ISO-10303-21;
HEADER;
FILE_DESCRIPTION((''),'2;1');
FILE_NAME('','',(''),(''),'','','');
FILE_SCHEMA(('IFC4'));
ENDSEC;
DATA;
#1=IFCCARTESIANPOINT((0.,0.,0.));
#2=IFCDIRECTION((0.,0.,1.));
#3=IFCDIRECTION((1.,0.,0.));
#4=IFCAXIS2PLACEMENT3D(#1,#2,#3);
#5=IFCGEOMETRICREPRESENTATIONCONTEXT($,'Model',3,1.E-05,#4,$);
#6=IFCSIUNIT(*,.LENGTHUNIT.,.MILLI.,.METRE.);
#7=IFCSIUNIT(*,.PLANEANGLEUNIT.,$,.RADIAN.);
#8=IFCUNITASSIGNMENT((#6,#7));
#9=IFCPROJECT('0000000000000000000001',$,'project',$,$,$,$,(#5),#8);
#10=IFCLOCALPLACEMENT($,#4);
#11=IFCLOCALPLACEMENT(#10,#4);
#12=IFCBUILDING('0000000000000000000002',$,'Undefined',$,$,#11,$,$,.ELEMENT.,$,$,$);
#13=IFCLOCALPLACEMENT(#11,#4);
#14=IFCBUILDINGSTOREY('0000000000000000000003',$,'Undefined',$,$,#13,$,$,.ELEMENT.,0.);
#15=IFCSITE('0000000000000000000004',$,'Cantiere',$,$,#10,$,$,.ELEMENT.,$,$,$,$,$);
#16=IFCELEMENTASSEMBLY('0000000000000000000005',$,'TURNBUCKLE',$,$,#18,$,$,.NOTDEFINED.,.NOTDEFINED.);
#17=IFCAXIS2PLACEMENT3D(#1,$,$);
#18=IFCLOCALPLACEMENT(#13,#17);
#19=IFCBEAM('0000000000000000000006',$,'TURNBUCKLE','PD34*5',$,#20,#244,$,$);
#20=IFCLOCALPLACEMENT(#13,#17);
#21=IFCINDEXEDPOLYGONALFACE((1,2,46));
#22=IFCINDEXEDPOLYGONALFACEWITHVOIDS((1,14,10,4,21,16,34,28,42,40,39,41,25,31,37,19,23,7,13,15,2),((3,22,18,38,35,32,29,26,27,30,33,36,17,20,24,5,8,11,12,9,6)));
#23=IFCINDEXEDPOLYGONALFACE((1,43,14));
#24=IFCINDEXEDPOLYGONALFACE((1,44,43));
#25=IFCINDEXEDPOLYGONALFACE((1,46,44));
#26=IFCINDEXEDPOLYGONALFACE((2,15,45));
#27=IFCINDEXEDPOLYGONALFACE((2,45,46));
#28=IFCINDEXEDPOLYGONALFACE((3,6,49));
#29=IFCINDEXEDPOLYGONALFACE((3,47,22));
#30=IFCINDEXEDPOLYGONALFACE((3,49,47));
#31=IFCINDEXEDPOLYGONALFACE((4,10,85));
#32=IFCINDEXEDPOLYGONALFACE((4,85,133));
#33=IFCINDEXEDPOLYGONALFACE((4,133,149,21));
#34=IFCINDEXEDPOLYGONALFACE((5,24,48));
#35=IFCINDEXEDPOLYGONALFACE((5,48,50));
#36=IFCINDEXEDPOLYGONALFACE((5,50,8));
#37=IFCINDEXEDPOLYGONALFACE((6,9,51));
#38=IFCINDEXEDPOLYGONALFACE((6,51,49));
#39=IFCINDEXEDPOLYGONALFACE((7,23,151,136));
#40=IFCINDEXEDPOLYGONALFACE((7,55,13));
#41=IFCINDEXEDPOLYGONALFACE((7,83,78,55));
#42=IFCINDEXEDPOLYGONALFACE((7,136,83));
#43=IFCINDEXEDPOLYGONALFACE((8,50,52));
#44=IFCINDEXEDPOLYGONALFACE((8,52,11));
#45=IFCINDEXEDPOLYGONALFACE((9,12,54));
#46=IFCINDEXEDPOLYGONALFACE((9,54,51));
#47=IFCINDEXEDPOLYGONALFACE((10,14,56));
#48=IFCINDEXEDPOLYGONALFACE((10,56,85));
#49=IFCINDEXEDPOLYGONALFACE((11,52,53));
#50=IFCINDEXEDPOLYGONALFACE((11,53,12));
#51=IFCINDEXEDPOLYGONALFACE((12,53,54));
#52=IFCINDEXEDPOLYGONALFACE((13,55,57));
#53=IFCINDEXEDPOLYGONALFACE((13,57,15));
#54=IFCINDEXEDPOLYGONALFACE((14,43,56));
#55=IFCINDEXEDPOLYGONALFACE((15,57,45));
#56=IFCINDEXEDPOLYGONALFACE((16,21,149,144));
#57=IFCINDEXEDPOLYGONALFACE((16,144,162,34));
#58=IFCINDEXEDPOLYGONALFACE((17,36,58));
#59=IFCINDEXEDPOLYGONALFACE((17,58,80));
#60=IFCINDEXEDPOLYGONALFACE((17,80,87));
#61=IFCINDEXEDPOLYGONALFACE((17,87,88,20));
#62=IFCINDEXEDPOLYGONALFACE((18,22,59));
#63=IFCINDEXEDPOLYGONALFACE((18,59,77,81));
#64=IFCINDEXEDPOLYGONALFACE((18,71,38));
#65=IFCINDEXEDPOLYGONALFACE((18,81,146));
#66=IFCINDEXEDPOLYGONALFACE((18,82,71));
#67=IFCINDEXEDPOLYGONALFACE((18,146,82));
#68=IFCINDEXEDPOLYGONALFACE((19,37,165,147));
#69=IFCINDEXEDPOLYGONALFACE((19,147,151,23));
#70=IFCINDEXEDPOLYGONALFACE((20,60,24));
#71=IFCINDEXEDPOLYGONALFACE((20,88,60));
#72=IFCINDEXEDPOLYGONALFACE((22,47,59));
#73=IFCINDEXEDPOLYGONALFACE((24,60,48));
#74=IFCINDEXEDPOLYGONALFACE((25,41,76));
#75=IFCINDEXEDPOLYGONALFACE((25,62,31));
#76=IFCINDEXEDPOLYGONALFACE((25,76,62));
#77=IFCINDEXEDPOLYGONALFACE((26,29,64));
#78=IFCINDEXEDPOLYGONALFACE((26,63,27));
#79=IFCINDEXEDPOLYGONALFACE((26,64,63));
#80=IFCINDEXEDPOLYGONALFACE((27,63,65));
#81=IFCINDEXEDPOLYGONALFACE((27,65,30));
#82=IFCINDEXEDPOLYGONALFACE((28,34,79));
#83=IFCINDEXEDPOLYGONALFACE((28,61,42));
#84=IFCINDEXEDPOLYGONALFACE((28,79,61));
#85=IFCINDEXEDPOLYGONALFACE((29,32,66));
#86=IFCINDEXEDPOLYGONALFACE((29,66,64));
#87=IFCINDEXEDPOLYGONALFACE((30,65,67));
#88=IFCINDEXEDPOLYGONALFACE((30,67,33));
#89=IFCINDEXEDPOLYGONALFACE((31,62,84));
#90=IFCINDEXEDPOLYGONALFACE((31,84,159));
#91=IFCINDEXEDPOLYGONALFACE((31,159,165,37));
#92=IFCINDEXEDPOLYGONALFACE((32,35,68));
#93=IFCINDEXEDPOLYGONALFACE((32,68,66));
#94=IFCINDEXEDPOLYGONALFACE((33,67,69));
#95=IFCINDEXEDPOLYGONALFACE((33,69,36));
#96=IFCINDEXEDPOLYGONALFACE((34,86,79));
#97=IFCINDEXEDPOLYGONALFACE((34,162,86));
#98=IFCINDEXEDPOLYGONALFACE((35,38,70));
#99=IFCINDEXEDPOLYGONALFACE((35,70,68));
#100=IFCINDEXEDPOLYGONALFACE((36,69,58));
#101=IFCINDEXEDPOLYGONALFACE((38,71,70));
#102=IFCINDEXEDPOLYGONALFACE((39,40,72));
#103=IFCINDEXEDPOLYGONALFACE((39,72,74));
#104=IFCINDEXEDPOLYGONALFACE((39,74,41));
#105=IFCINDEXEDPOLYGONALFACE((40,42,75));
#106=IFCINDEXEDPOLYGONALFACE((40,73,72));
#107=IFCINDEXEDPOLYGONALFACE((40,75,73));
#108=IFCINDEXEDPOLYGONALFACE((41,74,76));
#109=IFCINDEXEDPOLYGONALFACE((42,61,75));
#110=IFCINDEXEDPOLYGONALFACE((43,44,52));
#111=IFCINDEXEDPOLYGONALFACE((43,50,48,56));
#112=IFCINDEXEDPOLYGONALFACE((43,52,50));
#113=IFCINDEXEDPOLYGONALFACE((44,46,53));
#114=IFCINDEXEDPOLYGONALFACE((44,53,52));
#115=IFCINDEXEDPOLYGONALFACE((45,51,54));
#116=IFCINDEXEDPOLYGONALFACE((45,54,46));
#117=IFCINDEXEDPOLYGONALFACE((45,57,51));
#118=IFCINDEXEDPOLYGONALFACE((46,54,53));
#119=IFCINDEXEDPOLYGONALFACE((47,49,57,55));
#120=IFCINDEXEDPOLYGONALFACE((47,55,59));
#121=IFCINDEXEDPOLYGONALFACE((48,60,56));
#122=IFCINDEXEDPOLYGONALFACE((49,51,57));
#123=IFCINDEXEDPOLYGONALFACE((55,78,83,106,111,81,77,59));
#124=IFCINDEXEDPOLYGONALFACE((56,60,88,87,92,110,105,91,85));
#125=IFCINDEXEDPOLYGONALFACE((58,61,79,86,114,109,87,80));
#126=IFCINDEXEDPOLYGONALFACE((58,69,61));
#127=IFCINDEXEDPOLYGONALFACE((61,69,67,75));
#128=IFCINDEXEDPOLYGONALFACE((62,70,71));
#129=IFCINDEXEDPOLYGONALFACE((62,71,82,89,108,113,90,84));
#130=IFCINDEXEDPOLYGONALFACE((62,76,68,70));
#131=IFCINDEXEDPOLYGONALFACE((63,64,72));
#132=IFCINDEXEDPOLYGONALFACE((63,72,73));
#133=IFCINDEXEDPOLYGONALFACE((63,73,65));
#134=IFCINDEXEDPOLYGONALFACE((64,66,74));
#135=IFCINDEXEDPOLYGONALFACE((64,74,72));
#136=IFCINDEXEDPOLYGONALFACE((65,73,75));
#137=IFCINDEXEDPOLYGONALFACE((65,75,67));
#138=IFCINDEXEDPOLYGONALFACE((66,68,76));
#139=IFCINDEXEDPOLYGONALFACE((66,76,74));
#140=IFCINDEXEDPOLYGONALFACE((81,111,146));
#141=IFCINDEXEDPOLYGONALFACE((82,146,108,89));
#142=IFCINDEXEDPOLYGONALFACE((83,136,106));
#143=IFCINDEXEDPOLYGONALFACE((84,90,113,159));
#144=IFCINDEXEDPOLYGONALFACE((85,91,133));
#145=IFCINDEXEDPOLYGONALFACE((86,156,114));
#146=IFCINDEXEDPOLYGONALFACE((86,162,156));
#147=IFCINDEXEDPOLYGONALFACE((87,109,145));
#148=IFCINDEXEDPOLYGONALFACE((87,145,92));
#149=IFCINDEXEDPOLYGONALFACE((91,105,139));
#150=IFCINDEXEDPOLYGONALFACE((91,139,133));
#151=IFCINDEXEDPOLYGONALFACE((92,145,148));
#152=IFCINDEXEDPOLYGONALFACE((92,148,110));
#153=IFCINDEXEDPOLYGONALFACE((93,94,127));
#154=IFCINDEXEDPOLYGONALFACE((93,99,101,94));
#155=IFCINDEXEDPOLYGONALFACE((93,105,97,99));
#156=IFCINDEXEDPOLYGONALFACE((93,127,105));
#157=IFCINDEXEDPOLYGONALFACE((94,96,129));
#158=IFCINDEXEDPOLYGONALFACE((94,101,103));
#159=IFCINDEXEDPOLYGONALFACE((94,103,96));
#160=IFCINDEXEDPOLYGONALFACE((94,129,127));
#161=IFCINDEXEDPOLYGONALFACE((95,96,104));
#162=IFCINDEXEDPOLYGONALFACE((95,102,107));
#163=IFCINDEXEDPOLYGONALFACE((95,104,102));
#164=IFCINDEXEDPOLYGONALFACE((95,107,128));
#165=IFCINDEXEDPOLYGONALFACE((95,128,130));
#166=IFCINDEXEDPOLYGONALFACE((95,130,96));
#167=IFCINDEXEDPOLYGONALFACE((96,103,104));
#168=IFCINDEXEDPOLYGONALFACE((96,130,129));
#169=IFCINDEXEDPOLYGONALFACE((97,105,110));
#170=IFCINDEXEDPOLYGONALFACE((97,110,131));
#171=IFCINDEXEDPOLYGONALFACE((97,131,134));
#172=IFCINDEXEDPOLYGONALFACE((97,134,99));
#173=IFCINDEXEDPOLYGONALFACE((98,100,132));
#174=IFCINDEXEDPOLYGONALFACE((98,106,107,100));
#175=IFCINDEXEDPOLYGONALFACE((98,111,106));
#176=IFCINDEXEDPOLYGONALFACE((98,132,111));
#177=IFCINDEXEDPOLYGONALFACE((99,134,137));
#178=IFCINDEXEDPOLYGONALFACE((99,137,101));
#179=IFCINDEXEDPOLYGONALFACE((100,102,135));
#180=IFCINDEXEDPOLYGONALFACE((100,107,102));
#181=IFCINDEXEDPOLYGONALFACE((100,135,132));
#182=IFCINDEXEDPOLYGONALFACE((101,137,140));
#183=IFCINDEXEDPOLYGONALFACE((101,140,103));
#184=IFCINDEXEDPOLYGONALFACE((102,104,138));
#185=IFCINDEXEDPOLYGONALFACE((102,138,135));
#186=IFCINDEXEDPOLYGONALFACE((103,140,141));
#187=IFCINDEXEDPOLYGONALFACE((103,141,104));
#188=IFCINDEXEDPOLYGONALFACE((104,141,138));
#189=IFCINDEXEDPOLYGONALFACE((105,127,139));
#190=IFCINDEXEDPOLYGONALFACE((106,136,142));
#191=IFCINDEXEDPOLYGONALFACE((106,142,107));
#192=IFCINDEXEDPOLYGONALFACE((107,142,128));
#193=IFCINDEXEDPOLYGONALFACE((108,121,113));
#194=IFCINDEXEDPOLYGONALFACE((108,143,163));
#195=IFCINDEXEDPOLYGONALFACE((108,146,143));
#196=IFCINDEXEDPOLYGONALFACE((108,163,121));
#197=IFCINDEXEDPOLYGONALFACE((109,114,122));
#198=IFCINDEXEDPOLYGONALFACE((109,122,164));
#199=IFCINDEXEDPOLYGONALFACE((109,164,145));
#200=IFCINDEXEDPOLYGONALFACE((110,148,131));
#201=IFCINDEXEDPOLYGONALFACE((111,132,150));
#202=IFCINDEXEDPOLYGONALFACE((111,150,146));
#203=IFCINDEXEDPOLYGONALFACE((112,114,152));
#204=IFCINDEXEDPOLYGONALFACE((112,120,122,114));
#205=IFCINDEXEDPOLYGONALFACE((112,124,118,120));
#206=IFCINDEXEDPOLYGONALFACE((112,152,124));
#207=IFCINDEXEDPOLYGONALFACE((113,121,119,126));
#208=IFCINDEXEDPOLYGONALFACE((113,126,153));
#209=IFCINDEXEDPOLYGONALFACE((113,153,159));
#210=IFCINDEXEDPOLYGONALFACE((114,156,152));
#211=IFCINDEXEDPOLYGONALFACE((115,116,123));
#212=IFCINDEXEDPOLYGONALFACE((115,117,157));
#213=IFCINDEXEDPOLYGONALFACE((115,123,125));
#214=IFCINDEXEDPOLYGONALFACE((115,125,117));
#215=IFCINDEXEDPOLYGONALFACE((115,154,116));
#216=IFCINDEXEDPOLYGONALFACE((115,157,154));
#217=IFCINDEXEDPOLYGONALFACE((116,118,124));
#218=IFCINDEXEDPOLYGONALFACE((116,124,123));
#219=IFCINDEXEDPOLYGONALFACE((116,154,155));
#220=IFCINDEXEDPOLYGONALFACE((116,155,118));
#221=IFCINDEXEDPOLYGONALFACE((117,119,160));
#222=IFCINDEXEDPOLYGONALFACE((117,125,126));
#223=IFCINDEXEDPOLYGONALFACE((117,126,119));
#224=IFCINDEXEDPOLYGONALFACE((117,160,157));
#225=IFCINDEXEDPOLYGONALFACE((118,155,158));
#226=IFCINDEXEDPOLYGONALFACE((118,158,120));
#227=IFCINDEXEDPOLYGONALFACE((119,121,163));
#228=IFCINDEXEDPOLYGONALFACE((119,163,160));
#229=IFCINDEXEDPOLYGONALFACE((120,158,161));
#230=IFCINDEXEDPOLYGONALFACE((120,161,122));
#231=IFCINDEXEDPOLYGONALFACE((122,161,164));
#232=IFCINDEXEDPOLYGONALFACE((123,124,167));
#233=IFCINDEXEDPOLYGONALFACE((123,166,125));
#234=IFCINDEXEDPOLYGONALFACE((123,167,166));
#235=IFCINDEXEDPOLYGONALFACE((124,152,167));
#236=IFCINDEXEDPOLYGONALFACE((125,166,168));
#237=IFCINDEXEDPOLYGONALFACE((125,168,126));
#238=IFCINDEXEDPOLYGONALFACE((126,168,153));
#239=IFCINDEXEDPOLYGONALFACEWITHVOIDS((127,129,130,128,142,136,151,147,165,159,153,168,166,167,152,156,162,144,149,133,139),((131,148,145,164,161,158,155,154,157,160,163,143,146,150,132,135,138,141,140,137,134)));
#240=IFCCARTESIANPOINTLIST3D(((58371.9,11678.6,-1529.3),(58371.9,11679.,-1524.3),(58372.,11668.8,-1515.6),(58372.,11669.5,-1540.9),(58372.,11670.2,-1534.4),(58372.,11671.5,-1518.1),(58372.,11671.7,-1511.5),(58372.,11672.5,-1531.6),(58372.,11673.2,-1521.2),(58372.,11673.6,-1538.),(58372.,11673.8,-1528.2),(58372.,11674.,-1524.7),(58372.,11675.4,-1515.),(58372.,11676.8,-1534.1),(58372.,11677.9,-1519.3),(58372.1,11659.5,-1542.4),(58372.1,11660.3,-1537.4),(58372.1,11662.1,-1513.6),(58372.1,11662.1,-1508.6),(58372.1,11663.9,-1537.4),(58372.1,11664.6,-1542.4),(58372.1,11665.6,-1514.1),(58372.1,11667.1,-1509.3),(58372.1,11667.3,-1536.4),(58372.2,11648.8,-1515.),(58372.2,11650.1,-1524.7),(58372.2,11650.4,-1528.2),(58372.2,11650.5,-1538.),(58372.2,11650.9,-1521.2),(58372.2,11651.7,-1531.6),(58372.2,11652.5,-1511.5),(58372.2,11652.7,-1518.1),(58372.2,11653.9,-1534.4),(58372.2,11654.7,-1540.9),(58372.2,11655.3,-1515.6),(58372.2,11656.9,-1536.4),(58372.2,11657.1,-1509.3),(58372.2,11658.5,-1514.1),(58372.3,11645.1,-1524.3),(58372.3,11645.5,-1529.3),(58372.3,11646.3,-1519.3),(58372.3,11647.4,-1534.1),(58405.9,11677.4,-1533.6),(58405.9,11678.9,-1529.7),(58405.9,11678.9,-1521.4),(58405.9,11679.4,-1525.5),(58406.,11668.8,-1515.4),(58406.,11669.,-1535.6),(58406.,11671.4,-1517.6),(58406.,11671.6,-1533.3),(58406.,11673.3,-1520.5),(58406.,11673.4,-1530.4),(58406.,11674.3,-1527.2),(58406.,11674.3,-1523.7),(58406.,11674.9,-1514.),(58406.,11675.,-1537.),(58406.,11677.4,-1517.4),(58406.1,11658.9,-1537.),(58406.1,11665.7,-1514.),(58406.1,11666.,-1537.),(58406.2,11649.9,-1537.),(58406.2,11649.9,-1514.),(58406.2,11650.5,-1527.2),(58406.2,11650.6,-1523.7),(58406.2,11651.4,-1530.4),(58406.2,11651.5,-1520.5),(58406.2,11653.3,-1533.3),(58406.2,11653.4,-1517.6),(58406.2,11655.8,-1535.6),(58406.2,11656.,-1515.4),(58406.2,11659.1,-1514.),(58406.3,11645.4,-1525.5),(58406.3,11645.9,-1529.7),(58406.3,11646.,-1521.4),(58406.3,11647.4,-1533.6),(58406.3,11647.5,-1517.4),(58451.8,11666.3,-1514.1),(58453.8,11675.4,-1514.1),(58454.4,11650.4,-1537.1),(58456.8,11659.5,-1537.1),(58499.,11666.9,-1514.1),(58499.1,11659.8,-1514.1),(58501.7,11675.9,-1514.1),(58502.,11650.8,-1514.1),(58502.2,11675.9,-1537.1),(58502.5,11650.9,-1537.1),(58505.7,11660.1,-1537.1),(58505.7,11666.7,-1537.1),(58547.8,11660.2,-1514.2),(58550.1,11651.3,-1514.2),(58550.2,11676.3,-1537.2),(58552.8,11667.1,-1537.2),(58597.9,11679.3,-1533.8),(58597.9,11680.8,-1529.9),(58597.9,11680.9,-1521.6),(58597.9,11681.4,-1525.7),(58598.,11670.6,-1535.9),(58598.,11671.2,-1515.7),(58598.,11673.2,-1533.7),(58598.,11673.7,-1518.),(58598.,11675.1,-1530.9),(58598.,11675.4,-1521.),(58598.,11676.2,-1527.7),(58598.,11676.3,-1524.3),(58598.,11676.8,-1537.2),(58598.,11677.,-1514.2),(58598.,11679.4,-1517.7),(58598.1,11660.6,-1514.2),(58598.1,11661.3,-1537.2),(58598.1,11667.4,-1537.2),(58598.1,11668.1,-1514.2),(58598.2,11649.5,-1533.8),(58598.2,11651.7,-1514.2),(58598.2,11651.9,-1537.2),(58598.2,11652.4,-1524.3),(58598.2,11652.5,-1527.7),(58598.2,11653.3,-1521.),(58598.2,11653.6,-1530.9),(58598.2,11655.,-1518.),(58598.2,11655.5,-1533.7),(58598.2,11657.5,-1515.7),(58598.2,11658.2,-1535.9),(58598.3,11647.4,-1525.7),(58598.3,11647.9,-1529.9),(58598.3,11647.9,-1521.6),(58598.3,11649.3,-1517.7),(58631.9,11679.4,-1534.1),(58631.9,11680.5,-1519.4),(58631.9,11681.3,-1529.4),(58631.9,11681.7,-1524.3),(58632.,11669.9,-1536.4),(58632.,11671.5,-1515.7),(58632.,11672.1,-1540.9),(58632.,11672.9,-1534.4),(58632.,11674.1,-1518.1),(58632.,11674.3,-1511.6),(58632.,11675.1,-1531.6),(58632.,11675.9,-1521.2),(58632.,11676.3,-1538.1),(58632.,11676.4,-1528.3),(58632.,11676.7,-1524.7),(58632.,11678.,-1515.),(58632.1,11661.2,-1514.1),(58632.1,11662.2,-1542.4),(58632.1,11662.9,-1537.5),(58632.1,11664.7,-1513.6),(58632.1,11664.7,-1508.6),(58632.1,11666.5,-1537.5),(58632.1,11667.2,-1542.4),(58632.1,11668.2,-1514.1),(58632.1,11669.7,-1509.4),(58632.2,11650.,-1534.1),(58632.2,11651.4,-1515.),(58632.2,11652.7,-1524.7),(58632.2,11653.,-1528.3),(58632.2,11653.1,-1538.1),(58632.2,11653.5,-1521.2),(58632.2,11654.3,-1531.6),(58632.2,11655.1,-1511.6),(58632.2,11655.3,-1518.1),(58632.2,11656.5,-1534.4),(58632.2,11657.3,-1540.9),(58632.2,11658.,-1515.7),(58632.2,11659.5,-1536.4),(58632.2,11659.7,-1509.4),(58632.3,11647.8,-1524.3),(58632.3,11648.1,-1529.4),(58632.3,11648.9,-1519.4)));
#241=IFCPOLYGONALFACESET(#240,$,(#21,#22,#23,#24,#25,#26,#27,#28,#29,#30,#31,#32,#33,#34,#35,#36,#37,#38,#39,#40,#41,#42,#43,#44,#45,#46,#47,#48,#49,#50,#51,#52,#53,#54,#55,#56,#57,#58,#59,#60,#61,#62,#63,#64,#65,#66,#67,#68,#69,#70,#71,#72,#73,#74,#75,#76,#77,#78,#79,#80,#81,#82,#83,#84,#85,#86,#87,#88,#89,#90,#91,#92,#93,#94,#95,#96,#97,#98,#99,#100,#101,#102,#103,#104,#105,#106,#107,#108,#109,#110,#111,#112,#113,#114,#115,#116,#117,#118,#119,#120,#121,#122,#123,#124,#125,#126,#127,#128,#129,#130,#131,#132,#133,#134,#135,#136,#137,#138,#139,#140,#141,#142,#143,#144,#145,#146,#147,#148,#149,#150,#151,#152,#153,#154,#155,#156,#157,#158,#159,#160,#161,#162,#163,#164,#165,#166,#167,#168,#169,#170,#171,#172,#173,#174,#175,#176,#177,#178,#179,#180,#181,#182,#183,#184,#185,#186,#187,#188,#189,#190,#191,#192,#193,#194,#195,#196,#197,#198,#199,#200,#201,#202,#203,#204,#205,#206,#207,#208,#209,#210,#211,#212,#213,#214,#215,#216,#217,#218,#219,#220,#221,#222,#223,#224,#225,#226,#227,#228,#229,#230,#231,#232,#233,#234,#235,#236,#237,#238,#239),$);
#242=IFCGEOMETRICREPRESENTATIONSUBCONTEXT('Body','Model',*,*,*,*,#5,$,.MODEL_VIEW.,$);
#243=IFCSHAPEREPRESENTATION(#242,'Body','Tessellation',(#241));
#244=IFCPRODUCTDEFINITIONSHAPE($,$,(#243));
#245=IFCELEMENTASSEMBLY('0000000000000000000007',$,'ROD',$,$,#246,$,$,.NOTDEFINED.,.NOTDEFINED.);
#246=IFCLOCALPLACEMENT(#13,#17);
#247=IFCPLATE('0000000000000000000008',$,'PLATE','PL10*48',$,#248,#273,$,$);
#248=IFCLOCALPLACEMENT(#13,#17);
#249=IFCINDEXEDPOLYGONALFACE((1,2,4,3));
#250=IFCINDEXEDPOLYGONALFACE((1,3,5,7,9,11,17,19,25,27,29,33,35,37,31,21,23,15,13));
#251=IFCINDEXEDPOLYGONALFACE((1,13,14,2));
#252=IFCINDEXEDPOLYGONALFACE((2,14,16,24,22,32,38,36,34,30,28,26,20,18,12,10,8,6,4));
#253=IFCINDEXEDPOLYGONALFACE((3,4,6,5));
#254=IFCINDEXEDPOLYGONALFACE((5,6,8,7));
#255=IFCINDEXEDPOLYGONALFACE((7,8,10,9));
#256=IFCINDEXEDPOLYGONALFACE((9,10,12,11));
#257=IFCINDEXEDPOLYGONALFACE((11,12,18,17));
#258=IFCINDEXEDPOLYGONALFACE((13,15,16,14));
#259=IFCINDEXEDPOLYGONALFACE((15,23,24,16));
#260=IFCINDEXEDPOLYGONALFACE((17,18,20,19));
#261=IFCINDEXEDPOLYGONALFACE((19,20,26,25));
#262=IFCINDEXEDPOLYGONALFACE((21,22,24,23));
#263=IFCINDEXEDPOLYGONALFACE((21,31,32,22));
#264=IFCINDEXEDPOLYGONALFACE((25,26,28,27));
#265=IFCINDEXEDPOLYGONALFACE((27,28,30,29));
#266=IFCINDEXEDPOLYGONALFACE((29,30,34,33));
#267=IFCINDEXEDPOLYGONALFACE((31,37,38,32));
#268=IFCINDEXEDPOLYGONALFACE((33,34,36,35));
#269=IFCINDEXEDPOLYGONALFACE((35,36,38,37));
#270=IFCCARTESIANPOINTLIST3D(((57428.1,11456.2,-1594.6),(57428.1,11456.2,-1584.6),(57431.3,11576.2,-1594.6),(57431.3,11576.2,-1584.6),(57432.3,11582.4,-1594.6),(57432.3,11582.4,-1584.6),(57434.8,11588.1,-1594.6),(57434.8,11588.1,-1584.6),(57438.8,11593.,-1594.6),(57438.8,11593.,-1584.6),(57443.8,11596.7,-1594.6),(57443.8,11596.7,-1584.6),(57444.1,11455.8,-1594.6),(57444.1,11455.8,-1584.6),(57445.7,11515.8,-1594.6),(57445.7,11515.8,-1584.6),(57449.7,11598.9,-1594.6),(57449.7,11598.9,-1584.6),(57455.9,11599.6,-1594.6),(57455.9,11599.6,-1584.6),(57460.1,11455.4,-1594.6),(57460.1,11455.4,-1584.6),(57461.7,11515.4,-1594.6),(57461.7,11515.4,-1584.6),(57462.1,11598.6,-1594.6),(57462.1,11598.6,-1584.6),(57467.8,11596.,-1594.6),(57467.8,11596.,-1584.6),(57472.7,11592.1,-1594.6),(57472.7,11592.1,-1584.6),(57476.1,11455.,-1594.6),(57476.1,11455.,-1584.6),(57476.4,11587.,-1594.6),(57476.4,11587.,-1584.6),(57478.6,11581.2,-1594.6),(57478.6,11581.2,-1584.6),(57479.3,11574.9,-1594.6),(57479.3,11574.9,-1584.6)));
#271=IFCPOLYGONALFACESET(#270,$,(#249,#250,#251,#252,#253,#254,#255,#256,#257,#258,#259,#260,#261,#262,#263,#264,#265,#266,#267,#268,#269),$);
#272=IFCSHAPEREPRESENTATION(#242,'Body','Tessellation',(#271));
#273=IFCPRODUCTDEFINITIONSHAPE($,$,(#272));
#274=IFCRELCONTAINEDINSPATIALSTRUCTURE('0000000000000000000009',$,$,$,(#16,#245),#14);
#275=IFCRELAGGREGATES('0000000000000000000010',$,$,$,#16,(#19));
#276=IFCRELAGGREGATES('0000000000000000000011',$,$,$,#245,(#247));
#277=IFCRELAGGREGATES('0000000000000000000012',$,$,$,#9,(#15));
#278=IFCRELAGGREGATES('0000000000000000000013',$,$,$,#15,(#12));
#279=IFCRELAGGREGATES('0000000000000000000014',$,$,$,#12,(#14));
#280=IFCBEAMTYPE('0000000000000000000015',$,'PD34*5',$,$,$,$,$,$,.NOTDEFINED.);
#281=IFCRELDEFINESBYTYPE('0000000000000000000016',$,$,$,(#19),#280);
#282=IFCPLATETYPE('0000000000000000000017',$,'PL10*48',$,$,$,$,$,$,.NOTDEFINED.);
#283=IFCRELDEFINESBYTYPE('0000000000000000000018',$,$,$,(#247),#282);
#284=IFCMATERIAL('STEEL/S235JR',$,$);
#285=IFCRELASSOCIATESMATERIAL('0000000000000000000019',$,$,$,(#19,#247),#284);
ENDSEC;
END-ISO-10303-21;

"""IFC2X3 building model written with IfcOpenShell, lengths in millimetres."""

from ifc_helpers import new_model, si_unit, frame, frame_2d, origin_with_axes, origin_2d_with_axis, place, context, subcontext, project, spatial, polyline, circle_curve, parameter, trimmed, segment, composite_curve, rectangle, hollow_circle, outline, extrude, boolean, material, type_object, element, aggregate, save


model = new_model("IFC2X3")

# Units and contexts
model_context = context("Model", 3, precision=1e-05, world=origin_with_axes())
body_context = subcontext(model_context, "Body", "Model", "MODEL_VIEW")
ifc_project = project(units=[si_unit("LENGTHUNIT", "METRE", prefix="MILLI"), si_unit("PLANEANGLEUNIT", "RADIAN")], contexts=[model_context])

# Site, building, storey
site_placement = place(None, origin_with_axes())
site = spatial("IfcSite", under=ifc_project, at=site_placement, Name="Cantiere", CompositionType="ELEMENT")
building_placement = place(site_placement, origin_with_axes())
building = spatial("IfcBuilding", under=site, at=building_placement, Name="Undefined", CompositionType="ELEMENT")
storey_placement = place(building_placement, origin_with_axes())
storey = spatial("IfcBuildingStorey", under=building, at=storey_placement, Name="Undefined", CompositionType="ELEMENT", Elevation=0.0)

# Shared definitions
ifc_material_1 = material(Name="STEEL/S235JR")

# Element assembly, beam
assembly_1_placement = place(storey_placement, origin_with_axes())
assembly_1 = element("IfcElementAssembly", 1, at=assembly_1_placement, inside=storey, Name="TURNBUCKLE", AssemblyPlace="NOTDEFINED", PredefinedType="NOTDEFINED")
beam_type_1 = type_object("IfcBeamType", Name="PD34*5", PredefinedType="NOTDEFINED")
beam_1_placement = place(assembly_1_placement, frame((58632.1, 11664.7, -1525.6), z_axis=(0.010137, -0.999949, 0.0), x_axis=(-0.999949, -0.010137, 0.000189)))
beam_1 = element("IfcBeam", 2, at=beam_1_placement, type_object=beam_type_1, material=ifc_material_1, Name="TURNBUCKLE", Description="PD34*5", context=body_context, shape_type="CSG", body=[
    boolean("DIFFERENCE", extrude(hollow_circle(Radius=17.0, WallThickness=5.0, at=origin_2d_with_axis()), frame((260.0, 0.0, 0.0), z_axis=(-1.0, 0.0, 0.0), x_axis=(0.0, -1.0, 0.0)), (0.0, 0.0, 1.0), 260.0), extrude(rectangle(XDim=23.0, YDim=68.0, at=origin_2d_with_axis()), frame((226.0, 0.0, 0.0), z_axis=(-1.0, 0.000733, 0.0), x_axis=(-0.000733, -1.0, 0.0)), (0.0, 0.0, 1.0), 192.0)),
])
aggregate(assembly_1, [beam_1])

# Element assembly, plate
assembly_2_placement = place(storey_placement, origin_with_axes())
assembly_2 = element("IfcElementAssembly", 3, at=assembly_2_placement, inside=storey, Name="ROD", AssemblyPlace="NOTDEFINED", PredefinedType="NOTDEFINED")
plate_type_1 = type_object("IfcPlateType", Name="PL10*48", PredefinedType="NOTDEFINED")
plate_1_placement = place(assembly_2_placement, frame((57476.1, 11455.0, -1589.6), z_axis=(0.0, 0.0, 1.0), x_axis=(0.026238, 0.999656, 0.0)))
plate_1 = element("IfcPlate", 4, at=plate_1_placement, type_object=plate_type_1, material=ifc_material_1, Name="PLATE", Description="PL10*48", context=body_context, shape_type="SweptSolid", body=[
    extrude(outline(composite_curve([segment(polyline([(0.0, 0.0), (120.0, 0.0)]), True, "CONTINUOUS"), segment(trimmed(circle_curve(frame_2d((120.0, 24.0), x_axis=(0.0, -1.0)), 24.0), [parameter(0.0)], [parameter(1.570796)], True, "PARAMETER"), True, "CONTINUOUS"), segment(trimmed(circle_curve(frame_2d((120.0, 24.0), x_axis=(1.0, 0.0)), 24.0), [parameter(0.0)], [parameter(1.570796)], True, "PARAMETER"), True, "CONTINUOUS"), segment(polyline([(120.0, 48.0), (0.0, 48.0), (0.0, 32.0), (60.0, 32.0), (60.0, 16.0), (0.0, 16.0), (0.0, 0.0)]), True, "CONTINUOUS")], self_intersect=True)), frame((0.0, 0.0, -5.0), z_axis=(0.0, 0.0, 1.0), x_axis=(1.0, 0.0, 0.0)), (0.0, 0.0, 1.0), 10.0),
])

aggregate(assembly_2, [plate_1])

save(model, "model.ifc")
